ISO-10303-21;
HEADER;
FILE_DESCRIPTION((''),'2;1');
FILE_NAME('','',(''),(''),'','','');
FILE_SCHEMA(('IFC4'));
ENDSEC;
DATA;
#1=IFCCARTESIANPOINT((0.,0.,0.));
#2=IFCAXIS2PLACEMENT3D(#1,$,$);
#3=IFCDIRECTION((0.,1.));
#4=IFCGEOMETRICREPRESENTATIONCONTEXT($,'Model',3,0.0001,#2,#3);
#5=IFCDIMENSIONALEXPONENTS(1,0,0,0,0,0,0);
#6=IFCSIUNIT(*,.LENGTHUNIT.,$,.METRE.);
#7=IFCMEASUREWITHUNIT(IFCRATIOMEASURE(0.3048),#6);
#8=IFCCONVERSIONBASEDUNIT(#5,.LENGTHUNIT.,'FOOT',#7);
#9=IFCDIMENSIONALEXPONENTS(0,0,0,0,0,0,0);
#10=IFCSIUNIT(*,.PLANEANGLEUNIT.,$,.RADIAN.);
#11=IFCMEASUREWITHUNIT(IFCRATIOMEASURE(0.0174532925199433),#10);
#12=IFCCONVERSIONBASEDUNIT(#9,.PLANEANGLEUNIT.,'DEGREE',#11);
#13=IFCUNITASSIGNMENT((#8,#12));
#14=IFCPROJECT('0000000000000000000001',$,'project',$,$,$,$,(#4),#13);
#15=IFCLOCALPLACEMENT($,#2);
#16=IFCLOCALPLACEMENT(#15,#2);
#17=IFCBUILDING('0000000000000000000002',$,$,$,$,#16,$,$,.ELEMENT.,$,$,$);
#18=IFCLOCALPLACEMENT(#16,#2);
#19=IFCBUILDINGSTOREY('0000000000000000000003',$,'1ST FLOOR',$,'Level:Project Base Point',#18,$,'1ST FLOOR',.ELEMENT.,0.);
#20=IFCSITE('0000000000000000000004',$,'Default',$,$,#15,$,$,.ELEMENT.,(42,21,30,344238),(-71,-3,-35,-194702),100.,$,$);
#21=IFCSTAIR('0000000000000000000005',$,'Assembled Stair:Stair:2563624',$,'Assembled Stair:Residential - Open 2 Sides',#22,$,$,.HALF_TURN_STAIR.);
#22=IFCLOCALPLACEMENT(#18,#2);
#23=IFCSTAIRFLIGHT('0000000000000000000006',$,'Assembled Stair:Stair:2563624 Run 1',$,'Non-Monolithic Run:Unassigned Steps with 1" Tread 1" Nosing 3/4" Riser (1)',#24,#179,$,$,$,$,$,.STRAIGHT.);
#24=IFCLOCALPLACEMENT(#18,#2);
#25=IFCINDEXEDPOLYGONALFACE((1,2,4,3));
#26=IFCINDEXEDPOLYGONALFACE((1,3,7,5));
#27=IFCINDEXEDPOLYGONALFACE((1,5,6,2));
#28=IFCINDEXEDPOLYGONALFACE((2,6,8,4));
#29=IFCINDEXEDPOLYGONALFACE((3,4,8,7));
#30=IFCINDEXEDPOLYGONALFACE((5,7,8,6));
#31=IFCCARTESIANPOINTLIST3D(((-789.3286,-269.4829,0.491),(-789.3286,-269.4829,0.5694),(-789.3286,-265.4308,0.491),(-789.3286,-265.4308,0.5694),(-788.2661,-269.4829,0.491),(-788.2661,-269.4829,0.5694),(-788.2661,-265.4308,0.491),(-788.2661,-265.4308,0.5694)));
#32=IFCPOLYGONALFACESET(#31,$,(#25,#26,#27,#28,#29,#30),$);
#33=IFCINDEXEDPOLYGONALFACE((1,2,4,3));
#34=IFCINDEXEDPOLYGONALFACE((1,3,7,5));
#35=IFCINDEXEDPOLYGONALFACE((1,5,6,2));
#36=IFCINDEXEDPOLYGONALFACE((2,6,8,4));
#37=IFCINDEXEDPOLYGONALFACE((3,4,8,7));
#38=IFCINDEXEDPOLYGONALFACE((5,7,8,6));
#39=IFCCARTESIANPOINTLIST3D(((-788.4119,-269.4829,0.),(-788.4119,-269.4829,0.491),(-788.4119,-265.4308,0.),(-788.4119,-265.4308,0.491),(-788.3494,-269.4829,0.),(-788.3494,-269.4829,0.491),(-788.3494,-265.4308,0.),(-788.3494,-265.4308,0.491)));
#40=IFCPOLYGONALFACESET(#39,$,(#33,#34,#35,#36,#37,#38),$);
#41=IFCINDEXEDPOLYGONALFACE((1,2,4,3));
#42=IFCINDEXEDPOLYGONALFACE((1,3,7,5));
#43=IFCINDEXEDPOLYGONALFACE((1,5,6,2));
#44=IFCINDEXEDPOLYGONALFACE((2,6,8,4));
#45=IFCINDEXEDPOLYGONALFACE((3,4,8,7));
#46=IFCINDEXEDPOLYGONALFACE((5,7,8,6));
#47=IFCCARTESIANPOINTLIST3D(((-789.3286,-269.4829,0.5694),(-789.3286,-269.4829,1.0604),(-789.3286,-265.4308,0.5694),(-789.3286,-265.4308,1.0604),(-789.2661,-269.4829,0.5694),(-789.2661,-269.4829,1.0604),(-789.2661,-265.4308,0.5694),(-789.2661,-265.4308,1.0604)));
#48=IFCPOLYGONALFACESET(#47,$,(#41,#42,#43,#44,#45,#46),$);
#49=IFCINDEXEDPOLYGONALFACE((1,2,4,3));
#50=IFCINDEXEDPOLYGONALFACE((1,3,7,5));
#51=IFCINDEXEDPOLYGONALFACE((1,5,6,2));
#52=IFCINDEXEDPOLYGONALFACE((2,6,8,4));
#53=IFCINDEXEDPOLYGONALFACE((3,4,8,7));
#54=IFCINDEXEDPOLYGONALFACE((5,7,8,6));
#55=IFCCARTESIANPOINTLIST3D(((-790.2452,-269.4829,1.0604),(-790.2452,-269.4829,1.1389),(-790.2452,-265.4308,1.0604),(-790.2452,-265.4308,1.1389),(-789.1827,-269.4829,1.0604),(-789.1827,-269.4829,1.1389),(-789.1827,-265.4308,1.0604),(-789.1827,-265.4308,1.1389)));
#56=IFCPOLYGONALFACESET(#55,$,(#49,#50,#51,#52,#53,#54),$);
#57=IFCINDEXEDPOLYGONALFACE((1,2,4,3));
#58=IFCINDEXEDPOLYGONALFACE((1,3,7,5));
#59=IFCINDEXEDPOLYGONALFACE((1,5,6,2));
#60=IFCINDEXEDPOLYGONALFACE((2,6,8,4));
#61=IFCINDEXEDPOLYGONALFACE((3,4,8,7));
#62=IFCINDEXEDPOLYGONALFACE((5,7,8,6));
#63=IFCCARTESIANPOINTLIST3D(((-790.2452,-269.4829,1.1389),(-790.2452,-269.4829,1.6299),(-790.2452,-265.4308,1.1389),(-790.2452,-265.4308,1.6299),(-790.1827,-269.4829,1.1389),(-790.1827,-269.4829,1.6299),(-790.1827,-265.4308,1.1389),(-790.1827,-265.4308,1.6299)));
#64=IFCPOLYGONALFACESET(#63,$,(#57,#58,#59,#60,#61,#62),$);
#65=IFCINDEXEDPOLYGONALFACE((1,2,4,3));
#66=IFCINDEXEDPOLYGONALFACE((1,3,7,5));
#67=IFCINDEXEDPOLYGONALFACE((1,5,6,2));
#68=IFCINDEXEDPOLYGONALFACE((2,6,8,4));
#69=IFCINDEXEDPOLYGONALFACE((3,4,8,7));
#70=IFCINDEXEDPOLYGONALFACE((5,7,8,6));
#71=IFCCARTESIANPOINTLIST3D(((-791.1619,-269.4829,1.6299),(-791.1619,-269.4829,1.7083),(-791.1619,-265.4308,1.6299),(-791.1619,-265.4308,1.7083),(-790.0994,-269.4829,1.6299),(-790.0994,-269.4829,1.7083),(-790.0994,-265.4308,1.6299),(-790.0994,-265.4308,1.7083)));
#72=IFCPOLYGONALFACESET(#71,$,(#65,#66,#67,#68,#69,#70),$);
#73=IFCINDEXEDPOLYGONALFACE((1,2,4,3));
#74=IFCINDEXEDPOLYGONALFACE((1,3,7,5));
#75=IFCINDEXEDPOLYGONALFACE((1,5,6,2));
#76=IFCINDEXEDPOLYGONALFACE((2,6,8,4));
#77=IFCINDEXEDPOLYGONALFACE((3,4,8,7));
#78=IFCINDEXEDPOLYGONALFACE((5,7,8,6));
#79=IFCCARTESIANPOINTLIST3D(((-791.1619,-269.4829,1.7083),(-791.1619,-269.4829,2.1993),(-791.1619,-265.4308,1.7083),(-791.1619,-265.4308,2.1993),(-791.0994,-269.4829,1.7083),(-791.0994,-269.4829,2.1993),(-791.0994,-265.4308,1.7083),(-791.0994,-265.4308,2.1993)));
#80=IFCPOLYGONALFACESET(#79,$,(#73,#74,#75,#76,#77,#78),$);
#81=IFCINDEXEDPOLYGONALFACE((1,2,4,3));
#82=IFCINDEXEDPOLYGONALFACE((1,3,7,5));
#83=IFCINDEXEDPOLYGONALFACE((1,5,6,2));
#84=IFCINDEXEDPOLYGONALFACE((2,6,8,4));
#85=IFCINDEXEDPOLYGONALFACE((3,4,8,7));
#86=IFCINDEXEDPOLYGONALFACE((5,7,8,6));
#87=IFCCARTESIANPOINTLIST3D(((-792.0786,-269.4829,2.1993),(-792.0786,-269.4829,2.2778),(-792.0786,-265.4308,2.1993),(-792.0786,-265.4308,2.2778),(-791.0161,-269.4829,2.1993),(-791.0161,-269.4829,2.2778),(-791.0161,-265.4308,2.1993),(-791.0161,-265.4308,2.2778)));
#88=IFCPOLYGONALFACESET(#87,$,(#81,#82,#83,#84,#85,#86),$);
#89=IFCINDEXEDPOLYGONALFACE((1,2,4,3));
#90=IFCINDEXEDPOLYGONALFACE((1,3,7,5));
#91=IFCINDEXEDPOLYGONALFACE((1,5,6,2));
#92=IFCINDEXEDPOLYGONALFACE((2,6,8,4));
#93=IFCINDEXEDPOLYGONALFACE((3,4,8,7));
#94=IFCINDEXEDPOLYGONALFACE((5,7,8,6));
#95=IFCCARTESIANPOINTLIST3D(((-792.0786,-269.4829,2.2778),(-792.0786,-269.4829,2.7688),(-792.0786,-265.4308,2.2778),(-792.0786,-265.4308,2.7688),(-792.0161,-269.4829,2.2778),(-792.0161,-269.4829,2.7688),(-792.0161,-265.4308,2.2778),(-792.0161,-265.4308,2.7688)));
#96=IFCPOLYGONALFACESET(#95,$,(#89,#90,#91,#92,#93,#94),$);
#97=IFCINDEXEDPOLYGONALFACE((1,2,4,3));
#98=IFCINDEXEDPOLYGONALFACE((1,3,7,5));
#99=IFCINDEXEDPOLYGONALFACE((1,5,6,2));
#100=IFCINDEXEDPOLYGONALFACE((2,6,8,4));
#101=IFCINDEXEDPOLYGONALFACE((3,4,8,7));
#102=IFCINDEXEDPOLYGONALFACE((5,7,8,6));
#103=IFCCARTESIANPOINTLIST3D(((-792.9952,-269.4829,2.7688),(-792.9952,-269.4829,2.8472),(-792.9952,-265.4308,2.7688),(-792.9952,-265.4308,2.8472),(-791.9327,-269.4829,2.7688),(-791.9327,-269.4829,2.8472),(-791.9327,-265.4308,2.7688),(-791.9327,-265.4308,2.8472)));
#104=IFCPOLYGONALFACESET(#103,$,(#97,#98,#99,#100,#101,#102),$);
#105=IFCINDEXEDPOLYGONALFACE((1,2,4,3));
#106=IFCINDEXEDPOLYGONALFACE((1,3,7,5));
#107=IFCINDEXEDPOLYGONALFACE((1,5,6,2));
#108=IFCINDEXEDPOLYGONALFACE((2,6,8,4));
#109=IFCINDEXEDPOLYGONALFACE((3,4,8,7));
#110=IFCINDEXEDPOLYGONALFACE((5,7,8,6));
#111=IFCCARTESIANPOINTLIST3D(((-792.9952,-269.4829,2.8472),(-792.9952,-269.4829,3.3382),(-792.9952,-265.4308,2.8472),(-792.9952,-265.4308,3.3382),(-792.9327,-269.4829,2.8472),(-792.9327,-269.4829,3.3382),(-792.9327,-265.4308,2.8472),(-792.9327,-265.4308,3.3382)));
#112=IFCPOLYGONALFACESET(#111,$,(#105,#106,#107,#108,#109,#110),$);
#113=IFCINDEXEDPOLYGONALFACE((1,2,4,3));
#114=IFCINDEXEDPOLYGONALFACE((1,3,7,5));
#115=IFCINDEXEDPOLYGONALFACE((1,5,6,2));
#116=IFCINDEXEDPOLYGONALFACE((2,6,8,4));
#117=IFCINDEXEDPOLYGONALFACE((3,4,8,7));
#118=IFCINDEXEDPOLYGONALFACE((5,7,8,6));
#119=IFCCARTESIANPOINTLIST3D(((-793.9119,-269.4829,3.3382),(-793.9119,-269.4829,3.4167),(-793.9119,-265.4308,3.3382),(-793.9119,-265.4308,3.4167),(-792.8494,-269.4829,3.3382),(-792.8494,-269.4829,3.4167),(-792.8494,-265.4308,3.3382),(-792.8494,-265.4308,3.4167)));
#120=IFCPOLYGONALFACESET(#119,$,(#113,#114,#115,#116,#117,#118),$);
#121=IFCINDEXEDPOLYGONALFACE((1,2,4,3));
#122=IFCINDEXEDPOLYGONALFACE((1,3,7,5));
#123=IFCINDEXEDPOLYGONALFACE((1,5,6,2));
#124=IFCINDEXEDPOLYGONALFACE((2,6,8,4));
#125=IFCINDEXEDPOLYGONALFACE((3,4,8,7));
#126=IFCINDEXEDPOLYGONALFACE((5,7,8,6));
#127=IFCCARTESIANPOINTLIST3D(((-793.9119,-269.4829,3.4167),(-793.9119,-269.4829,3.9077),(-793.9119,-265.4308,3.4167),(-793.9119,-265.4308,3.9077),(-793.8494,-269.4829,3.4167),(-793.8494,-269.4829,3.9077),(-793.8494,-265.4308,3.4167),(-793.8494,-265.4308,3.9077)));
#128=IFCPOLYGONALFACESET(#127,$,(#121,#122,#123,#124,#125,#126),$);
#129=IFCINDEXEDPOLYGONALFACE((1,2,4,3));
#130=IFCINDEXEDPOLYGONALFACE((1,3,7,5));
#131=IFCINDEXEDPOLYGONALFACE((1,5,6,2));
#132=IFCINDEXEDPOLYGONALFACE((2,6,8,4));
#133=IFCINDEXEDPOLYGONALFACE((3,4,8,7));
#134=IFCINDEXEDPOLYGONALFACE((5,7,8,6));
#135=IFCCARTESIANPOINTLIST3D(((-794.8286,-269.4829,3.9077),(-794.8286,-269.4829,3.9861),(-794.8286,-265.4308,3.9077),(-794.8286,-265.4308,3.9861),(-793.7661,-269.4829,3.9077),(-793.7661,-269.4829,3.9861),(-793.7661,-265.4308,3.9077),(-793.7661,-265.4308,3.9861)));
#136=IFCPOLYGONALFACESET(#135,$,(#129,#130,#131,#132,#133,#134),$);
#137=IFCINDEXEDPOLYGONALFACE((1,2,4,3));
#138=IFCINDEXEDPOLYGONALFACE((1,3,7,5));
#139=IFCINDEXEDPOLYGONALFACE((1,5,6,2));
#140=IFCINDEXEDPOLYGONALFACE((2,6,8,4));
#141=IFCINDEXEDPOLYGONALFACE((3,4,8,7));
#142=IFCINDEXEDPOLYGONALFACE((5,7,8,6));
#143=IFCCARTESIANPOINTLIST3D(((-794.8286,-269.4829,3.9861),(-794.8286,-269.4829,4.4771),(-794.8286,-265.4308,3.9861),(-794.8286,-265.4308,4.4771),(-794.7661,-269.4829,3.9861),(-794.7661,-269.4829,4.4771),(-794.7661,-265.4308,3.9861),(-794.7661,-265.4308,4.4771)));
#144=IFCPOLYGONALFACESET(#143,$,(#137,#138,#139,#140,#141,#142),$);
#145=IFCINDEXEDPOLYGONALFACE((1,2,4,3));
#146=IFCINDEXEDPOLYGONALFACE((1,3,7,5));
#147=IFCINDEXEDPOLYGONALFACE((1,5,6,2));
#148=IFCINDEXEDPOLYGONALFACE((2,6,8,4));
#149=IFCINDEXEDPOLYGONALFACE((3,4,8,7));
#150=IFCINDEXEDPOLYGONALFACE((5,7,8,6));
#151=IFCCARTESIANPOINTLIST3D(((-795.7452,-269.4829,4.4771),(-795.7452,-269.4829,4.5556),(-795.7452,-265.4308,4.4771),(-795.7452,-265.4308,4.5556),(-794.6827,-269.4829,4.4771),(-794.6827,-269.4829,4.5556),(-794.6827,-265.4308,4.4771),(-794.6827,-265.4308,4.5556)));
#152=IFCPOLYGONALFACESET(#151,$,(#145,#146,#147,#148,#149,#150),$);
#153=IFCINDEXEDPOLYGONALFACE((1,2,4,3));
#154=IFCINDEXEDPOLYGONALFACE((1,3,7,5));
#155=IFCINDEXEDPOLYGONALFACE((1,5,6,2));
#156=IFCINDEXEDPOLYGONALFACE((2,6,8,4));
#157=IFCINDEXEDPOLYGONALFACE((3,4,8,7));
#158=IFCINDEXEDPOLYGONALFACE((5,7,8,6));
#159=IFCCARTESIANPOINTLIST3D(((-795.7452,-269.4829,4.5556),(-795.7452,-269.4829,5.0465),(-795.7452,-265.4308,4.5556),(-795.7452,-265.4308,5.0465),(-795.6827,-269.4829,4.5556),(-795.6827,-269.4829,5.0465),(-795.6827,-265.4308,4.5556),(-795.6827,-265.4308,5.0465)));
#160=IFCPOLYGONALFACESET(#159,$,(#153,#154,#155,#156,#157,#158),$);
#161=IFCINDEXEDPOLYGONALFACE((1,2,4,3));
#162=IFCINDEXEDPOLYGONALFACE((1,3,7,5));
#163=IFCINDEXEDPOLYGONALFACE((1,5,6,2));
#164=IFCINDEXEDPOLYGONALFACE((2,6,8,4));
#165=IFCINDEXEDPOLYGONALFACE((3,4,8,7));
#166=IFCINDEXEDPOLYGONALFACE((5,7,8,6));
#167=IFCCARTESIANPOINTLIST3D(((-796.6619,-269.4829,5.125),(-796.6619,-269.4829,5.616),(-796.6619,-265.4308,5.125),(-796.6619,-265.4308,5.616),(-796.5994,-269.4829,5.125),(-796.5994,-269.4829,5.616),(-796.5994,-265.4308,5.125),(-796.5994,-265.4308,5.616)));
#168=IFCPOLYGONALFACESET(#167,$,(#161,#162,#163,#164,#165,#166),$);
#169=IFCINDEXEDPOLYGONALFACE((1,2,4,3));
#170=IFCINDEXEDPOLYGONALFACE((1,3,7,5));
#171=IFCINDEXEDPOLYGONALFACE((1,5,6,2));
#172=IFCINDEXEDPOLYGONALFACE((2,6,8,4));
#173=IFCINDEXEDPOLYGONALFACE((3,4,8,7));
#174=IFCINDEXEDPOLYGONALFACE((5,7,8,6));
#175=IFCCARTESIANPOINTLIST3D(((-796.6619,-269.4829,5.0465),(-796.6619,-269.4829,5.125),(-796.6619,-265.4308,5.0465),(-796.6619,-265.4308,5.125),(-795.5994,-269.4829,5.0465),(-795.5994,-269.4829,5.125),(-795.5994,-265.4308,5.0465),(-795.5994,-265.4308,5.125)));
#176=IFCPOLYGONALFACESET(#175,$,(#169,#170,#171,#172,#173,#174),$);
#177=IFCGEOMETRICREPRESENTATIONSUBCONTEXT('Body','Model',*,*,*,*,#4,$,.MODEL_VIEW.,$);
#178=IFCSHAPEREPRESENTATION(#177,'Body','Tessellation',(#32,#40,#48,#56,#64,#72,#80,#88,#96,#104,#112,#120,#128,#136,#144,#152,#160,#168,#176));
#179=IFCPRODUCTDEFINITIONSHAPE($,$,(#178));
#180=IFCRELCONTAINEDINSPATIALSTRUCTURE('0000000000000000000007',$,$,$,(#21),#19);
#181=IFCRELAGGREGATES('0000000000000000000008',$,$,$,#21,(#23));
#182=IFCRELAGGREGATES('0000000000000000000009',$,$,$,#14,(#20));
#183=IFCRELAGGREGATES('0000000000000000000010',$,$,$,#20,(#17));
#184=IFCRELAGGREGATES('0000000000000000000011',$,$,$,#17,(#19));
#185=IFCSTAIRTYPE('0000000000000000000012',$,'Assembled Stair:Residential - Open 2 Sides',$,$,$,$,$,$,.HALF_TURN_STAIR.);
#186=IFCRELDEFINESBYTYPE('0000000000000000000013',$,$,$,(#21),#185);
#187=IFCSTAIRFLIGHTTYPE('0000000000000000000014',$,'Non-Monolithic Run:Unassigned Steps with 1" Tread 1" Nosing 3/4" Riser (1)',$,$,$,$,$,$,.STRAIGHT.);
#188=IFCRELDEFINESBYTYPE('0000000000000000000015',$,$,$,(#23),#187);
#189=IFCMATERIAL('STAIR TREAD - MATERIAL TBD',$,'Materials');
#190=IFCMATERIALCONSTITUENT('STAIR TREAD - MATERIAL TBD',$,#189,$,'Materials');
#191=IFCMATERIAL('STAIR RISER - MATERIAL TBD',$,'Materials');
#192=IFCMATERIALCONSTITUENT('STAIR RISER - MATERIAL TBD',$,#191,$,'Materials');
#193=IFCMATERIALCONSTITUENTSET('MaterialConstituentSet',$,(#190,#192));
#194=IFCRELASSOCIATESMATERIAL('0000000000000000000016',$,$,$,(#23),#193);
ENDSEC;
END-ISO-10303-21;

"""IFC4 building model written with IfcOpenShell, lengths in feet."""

from ifc_helpers import new_model, entity, si_unit, converted_unit, direction, frame, frame_2d, origin, origin_2d_with_axis, place, context, subcontext, project, spatial, rectangle, extrude, material, constituent, constituent_set, type_object, element, aggregate, save


model = new_model("IFC4")

# Units and contexts
model_context = context("Model", 3, precision=0.0001, world=origin(), true_north=direction((0.0, 1.0)))
body_context = subcontext(model_context, "Body", "Model", "MODEL_VIEW")
ifc_project = project(units=[converted_unit("LENGTHUNIT", "FOOT", entity("IfcRatioMeasure", 0.3048), si_unit("LENGTHUNIT", "METRE"), dimensions=[1, 0, 0, 0, 0, 0, 0]), converted_unit("PLANEANGLEUNIT", "DEGREE", entity("IfcRatioMeasure", 0.0174532925199433), si_unit("PLANEANGLEUNIT", "RADIAN"), dimensions=[0, 0, 0, 0, 0, 0, 0])], contexts=[model_context])

# Site, building, storey
site_placement = place(None, origin())
site = spatial("IfcSite", under=ifc_project, at=site_placement, Name="Default", CompositionType="ELEMENT", RefLatitude=(42, 21, 30, 344238), RefLongitude=(-71, -3, -35, -194702), RefElevation=100.0)
building_placement = place(site_placement, origin())
building = spatial("IfcBuilding", under=site, at=building_placement, CompositionType="ELEMENT")
storey_placement = place(building_placement, origin())
storey = spatial("IfcBuildingStorey", under=building, at=storey_placement, Name="1ST FLOOR", ObjectType="Level:Project Base Point", LongName="1ST FLOOR", CompositionType="ELEMENT", Elevation=0.0)

# Stair
stair_type_1 = type_object("IfcStairType", Name="Assembled Stair:Residential - Open 2 Sides", PredefinedType="HALF_TURN_STAIR")
stair_1_placement = place(storey_placement, origin())
stair_1 = element("IfcStair", 1, at=stair_1_placement, inside=storey, type_object=stair_type_1, Name="Assembled Stair:Stair:2563624", ObjectType="Assembled Stair:Residential - Open 2 Sides", PredefinedType="HALF_TURN_STAIR")

# Stair flight
ifc_material_1 = material(Name="STAIR TREAD - MATERIAL TBD", Category="Materials")
ifc_constituent_1 = constituent(ifc_material_1, Name="STAIR TREAD - MATERIAL TBD", Category="Materials")
ifc_material_2 = material(Name="STAIR RISER - MATERIAL TBD", Category="Materials")
ifc_constituent_2 = constituent(ifc_material_2, Name="STAIR RISER - MATERIAL TBD", Category="Materials")
ifc_constituent_set_1 = constituent_set(constituents=[ifc_constituent_1, ifc_constituent_2], Name="MaterialConstituentSet")
stair_flight_type_1 = type_object("IfcStairFlightType", Name="Non-Monolithic Run:Unassigned Steps with 1\" Tread 1\" Nosing 3/4\" Riser (1)", PredefinedType="STRAIGHT")
stair_flight_1_placement = place(stair_1_placement, frame((-796.6619, -269.4829, 0.0)))
stair_flight_1 = element("IfcStairFlight", 2, at=stair_flight_1_placement, type_object=stair_flight_type_1, material=ifc_constituent_set_1, Name="Assembled Stair:Stair:2563624 Run 1", ObjectType="Non-Monolithic Run:Unassigned Steps with 1\" Tread 1\" Nosing 3/4\" Riser (1)", PredefinedType="STRAIGHT", context=body_context, shape_type="SweptSolid", body=[
    extrude(rectangle(XDim=1.0625, YDim=4.0521, at=frame_2d((0.0, 0.0), x_axis=(1.0, 0.0))), frame((7.8646, 2.026, 0.491)), (0.0, 0.0, 1.0), 0.0785),
    extrude(rectangle(XDim=4.0521, YDim=0.0625, at=origin_2d_with_axis()), frame((8.2813, 2.026, 0.0), z_axis=(0.0, 0.0, 1.0), x_axis=(0.0, -1.0, 0.0)), (0.0, 0.0, 1.0), 0.491),
    extrude(rectangle(XDim=4.0521, YDim=0.0625, at=origin_2d_with_axis()), frame((7.3646, 2.026, 0.5694), z_axis=(0.0, 0.0, 1.0), x_axis=(0.0, -1.0, 0.0)), (0.0, 0.0, 1.0), 0.491),
    extrude(rectangle(XDim=1.0625, YDim=4.0521, at=origin_2d_with_axis()), frame((6.9479, 2.026, 1.0604)), (0.0, 0.0, 1.0), 0.0785),
    extrude(rectangle(XDim=4.0521, YDim=0.0625, at=origin_2d_with_axis()), frame((6.4479, 2.026, 1.1389), z_axis=(0.0, 0.0, 1.0), x_axis=(0.0, -1.0, 0.0)), (0.0, 0.0, 1.0), 0.491),
    extrude(rectangle(XDim=1.0625, YDim=4.0521, at=origin_2d_with_axis()), frame((6.0313, 2.026, 1.6299)), (0.0, 0.0, 1.0), 0.0785),
    extrude(rectangle(XDim=4.0521, YDim=0.0625, at=origin_2d_with_axis()), frame((5.5313, 2.026, 1.7083), z_axis=(0.0, 0.0, 1.0), x_axis=(0.0, -1.0, 0.0)), (0.0, 0.0, 1.0), 0.491),
    extrude(rectangle(XDim=1.0625, YDim=4.0521, at=frame_2d((0.0, 0.0), x_axis=(1.0, 0.0))), frame((5.1146, 2.026, 2.1993)), (0.0, 0.0, 1.0), 0.0785),
    extrude(rectangle(XDim=4.0521, YDim=0.0625, at=origin_2d_with_axis()), frame((4.6146, 2.026, 2.2778), z_axis=(0.0, 0.0, 1.0), x_axis=(0.0, -1.0, 0.0)), (0.0, 0.0, 1.0), 0.491),
    extrude(rectangle(XDim=1.0625, YDim=4.0521, at=frame_2d((0.0, 0.0), x_axis=(1.0, 0.0))), frame((4.1979, 2.026, 2.7688)), (0.0, 0.0, 1.0), 0.0785),
    extrude(rectangle(XDim=4.0521, YDim=0.0625, at=frame_2d((0.0, 0.0), x_axis=(1.0, 0.0))), frame((3.6979, 2.026, 2.8472), z_axis=(0.0, 0.0, 1.0), x_axis=(0.0, -1.0, 0.0)), (0.0, 0.0, 1.0), 0.491),
    extrude(rectangle(XDim=1.0625, YDim=4.0521, at=origin_2d_with_axis()), frame((3.2813, 2.026, 3.3382)), (0.0, 0.0, 1.0), 0.0785),
    extrude(rectangle(XDim=4.0521, YDim=0.0625, at=frame_2d((0.0, 0.0), x_axis=(1.0, 0.0))), frame((2.7813, 2.026, 3.4167), z_axis=(0.0, 0.0, 1.0), x_axis=(0.0, -1.0, 0.0)), (0.0, 0.0, 1.0), 0.491),
    extrude(rectangle(XDim=1.0625, YDim=4.0521, at=origin_2d_with_axis()), frame((2.3646, 2.026, 3.9077)), (0.0, 0.0, 1.0), 0.0785),
    extrude(rectangle(XDim=4.0521, YDim=0.0625, at=origin_2d_with_axis()), frame((1.8646, 2.026, 3.9861), z_axis=(0.0, 0.0, 1.0), x_axis=(0.0, -1.0, 0.0)), (0.0, 0.0, 1.0), 0.491),
    extrude(rectangle(XDim=1.0625, YDim=4.0521, at=origin_2d_with_axis()), frame((1.4479, 2.026, 4.4771)), (0.0, 0.0, 1.0), 0.0785),
    extrude(rectangle(XDim=4.0521, YDim=0.0625, at=origin_2d_with_axis()), frame((0.9479, 2.026, 4.5556), z_axis=(0.0, 0.0, 1.0), x_axis=(0.0, -1.0, 0.0)), (0.0, 0.0, 1.0), 0.491),
    extrude(rectangle(XDim=4.0521, YDim=0.0625, at=origin_2d_with_axis()), frame((0.0313, 2.026, 5.125), z_axis=(0.0, 0.0, 1.0), x_axis=(0.0, -1.0, 0.0)), (0.0, 0.0, 1.0), 0.491),
    extrude(rectangle(XDim=1.0625, YDim=4.0521, at=origin_2d_with_axis()), frame((0.5313, 2.026, 5.0465)), (0.0, 0.0, 1.0), 0.0785),
])
aggregate(stair_1, [stair_flight_1])

save(model, "model.ifc")
